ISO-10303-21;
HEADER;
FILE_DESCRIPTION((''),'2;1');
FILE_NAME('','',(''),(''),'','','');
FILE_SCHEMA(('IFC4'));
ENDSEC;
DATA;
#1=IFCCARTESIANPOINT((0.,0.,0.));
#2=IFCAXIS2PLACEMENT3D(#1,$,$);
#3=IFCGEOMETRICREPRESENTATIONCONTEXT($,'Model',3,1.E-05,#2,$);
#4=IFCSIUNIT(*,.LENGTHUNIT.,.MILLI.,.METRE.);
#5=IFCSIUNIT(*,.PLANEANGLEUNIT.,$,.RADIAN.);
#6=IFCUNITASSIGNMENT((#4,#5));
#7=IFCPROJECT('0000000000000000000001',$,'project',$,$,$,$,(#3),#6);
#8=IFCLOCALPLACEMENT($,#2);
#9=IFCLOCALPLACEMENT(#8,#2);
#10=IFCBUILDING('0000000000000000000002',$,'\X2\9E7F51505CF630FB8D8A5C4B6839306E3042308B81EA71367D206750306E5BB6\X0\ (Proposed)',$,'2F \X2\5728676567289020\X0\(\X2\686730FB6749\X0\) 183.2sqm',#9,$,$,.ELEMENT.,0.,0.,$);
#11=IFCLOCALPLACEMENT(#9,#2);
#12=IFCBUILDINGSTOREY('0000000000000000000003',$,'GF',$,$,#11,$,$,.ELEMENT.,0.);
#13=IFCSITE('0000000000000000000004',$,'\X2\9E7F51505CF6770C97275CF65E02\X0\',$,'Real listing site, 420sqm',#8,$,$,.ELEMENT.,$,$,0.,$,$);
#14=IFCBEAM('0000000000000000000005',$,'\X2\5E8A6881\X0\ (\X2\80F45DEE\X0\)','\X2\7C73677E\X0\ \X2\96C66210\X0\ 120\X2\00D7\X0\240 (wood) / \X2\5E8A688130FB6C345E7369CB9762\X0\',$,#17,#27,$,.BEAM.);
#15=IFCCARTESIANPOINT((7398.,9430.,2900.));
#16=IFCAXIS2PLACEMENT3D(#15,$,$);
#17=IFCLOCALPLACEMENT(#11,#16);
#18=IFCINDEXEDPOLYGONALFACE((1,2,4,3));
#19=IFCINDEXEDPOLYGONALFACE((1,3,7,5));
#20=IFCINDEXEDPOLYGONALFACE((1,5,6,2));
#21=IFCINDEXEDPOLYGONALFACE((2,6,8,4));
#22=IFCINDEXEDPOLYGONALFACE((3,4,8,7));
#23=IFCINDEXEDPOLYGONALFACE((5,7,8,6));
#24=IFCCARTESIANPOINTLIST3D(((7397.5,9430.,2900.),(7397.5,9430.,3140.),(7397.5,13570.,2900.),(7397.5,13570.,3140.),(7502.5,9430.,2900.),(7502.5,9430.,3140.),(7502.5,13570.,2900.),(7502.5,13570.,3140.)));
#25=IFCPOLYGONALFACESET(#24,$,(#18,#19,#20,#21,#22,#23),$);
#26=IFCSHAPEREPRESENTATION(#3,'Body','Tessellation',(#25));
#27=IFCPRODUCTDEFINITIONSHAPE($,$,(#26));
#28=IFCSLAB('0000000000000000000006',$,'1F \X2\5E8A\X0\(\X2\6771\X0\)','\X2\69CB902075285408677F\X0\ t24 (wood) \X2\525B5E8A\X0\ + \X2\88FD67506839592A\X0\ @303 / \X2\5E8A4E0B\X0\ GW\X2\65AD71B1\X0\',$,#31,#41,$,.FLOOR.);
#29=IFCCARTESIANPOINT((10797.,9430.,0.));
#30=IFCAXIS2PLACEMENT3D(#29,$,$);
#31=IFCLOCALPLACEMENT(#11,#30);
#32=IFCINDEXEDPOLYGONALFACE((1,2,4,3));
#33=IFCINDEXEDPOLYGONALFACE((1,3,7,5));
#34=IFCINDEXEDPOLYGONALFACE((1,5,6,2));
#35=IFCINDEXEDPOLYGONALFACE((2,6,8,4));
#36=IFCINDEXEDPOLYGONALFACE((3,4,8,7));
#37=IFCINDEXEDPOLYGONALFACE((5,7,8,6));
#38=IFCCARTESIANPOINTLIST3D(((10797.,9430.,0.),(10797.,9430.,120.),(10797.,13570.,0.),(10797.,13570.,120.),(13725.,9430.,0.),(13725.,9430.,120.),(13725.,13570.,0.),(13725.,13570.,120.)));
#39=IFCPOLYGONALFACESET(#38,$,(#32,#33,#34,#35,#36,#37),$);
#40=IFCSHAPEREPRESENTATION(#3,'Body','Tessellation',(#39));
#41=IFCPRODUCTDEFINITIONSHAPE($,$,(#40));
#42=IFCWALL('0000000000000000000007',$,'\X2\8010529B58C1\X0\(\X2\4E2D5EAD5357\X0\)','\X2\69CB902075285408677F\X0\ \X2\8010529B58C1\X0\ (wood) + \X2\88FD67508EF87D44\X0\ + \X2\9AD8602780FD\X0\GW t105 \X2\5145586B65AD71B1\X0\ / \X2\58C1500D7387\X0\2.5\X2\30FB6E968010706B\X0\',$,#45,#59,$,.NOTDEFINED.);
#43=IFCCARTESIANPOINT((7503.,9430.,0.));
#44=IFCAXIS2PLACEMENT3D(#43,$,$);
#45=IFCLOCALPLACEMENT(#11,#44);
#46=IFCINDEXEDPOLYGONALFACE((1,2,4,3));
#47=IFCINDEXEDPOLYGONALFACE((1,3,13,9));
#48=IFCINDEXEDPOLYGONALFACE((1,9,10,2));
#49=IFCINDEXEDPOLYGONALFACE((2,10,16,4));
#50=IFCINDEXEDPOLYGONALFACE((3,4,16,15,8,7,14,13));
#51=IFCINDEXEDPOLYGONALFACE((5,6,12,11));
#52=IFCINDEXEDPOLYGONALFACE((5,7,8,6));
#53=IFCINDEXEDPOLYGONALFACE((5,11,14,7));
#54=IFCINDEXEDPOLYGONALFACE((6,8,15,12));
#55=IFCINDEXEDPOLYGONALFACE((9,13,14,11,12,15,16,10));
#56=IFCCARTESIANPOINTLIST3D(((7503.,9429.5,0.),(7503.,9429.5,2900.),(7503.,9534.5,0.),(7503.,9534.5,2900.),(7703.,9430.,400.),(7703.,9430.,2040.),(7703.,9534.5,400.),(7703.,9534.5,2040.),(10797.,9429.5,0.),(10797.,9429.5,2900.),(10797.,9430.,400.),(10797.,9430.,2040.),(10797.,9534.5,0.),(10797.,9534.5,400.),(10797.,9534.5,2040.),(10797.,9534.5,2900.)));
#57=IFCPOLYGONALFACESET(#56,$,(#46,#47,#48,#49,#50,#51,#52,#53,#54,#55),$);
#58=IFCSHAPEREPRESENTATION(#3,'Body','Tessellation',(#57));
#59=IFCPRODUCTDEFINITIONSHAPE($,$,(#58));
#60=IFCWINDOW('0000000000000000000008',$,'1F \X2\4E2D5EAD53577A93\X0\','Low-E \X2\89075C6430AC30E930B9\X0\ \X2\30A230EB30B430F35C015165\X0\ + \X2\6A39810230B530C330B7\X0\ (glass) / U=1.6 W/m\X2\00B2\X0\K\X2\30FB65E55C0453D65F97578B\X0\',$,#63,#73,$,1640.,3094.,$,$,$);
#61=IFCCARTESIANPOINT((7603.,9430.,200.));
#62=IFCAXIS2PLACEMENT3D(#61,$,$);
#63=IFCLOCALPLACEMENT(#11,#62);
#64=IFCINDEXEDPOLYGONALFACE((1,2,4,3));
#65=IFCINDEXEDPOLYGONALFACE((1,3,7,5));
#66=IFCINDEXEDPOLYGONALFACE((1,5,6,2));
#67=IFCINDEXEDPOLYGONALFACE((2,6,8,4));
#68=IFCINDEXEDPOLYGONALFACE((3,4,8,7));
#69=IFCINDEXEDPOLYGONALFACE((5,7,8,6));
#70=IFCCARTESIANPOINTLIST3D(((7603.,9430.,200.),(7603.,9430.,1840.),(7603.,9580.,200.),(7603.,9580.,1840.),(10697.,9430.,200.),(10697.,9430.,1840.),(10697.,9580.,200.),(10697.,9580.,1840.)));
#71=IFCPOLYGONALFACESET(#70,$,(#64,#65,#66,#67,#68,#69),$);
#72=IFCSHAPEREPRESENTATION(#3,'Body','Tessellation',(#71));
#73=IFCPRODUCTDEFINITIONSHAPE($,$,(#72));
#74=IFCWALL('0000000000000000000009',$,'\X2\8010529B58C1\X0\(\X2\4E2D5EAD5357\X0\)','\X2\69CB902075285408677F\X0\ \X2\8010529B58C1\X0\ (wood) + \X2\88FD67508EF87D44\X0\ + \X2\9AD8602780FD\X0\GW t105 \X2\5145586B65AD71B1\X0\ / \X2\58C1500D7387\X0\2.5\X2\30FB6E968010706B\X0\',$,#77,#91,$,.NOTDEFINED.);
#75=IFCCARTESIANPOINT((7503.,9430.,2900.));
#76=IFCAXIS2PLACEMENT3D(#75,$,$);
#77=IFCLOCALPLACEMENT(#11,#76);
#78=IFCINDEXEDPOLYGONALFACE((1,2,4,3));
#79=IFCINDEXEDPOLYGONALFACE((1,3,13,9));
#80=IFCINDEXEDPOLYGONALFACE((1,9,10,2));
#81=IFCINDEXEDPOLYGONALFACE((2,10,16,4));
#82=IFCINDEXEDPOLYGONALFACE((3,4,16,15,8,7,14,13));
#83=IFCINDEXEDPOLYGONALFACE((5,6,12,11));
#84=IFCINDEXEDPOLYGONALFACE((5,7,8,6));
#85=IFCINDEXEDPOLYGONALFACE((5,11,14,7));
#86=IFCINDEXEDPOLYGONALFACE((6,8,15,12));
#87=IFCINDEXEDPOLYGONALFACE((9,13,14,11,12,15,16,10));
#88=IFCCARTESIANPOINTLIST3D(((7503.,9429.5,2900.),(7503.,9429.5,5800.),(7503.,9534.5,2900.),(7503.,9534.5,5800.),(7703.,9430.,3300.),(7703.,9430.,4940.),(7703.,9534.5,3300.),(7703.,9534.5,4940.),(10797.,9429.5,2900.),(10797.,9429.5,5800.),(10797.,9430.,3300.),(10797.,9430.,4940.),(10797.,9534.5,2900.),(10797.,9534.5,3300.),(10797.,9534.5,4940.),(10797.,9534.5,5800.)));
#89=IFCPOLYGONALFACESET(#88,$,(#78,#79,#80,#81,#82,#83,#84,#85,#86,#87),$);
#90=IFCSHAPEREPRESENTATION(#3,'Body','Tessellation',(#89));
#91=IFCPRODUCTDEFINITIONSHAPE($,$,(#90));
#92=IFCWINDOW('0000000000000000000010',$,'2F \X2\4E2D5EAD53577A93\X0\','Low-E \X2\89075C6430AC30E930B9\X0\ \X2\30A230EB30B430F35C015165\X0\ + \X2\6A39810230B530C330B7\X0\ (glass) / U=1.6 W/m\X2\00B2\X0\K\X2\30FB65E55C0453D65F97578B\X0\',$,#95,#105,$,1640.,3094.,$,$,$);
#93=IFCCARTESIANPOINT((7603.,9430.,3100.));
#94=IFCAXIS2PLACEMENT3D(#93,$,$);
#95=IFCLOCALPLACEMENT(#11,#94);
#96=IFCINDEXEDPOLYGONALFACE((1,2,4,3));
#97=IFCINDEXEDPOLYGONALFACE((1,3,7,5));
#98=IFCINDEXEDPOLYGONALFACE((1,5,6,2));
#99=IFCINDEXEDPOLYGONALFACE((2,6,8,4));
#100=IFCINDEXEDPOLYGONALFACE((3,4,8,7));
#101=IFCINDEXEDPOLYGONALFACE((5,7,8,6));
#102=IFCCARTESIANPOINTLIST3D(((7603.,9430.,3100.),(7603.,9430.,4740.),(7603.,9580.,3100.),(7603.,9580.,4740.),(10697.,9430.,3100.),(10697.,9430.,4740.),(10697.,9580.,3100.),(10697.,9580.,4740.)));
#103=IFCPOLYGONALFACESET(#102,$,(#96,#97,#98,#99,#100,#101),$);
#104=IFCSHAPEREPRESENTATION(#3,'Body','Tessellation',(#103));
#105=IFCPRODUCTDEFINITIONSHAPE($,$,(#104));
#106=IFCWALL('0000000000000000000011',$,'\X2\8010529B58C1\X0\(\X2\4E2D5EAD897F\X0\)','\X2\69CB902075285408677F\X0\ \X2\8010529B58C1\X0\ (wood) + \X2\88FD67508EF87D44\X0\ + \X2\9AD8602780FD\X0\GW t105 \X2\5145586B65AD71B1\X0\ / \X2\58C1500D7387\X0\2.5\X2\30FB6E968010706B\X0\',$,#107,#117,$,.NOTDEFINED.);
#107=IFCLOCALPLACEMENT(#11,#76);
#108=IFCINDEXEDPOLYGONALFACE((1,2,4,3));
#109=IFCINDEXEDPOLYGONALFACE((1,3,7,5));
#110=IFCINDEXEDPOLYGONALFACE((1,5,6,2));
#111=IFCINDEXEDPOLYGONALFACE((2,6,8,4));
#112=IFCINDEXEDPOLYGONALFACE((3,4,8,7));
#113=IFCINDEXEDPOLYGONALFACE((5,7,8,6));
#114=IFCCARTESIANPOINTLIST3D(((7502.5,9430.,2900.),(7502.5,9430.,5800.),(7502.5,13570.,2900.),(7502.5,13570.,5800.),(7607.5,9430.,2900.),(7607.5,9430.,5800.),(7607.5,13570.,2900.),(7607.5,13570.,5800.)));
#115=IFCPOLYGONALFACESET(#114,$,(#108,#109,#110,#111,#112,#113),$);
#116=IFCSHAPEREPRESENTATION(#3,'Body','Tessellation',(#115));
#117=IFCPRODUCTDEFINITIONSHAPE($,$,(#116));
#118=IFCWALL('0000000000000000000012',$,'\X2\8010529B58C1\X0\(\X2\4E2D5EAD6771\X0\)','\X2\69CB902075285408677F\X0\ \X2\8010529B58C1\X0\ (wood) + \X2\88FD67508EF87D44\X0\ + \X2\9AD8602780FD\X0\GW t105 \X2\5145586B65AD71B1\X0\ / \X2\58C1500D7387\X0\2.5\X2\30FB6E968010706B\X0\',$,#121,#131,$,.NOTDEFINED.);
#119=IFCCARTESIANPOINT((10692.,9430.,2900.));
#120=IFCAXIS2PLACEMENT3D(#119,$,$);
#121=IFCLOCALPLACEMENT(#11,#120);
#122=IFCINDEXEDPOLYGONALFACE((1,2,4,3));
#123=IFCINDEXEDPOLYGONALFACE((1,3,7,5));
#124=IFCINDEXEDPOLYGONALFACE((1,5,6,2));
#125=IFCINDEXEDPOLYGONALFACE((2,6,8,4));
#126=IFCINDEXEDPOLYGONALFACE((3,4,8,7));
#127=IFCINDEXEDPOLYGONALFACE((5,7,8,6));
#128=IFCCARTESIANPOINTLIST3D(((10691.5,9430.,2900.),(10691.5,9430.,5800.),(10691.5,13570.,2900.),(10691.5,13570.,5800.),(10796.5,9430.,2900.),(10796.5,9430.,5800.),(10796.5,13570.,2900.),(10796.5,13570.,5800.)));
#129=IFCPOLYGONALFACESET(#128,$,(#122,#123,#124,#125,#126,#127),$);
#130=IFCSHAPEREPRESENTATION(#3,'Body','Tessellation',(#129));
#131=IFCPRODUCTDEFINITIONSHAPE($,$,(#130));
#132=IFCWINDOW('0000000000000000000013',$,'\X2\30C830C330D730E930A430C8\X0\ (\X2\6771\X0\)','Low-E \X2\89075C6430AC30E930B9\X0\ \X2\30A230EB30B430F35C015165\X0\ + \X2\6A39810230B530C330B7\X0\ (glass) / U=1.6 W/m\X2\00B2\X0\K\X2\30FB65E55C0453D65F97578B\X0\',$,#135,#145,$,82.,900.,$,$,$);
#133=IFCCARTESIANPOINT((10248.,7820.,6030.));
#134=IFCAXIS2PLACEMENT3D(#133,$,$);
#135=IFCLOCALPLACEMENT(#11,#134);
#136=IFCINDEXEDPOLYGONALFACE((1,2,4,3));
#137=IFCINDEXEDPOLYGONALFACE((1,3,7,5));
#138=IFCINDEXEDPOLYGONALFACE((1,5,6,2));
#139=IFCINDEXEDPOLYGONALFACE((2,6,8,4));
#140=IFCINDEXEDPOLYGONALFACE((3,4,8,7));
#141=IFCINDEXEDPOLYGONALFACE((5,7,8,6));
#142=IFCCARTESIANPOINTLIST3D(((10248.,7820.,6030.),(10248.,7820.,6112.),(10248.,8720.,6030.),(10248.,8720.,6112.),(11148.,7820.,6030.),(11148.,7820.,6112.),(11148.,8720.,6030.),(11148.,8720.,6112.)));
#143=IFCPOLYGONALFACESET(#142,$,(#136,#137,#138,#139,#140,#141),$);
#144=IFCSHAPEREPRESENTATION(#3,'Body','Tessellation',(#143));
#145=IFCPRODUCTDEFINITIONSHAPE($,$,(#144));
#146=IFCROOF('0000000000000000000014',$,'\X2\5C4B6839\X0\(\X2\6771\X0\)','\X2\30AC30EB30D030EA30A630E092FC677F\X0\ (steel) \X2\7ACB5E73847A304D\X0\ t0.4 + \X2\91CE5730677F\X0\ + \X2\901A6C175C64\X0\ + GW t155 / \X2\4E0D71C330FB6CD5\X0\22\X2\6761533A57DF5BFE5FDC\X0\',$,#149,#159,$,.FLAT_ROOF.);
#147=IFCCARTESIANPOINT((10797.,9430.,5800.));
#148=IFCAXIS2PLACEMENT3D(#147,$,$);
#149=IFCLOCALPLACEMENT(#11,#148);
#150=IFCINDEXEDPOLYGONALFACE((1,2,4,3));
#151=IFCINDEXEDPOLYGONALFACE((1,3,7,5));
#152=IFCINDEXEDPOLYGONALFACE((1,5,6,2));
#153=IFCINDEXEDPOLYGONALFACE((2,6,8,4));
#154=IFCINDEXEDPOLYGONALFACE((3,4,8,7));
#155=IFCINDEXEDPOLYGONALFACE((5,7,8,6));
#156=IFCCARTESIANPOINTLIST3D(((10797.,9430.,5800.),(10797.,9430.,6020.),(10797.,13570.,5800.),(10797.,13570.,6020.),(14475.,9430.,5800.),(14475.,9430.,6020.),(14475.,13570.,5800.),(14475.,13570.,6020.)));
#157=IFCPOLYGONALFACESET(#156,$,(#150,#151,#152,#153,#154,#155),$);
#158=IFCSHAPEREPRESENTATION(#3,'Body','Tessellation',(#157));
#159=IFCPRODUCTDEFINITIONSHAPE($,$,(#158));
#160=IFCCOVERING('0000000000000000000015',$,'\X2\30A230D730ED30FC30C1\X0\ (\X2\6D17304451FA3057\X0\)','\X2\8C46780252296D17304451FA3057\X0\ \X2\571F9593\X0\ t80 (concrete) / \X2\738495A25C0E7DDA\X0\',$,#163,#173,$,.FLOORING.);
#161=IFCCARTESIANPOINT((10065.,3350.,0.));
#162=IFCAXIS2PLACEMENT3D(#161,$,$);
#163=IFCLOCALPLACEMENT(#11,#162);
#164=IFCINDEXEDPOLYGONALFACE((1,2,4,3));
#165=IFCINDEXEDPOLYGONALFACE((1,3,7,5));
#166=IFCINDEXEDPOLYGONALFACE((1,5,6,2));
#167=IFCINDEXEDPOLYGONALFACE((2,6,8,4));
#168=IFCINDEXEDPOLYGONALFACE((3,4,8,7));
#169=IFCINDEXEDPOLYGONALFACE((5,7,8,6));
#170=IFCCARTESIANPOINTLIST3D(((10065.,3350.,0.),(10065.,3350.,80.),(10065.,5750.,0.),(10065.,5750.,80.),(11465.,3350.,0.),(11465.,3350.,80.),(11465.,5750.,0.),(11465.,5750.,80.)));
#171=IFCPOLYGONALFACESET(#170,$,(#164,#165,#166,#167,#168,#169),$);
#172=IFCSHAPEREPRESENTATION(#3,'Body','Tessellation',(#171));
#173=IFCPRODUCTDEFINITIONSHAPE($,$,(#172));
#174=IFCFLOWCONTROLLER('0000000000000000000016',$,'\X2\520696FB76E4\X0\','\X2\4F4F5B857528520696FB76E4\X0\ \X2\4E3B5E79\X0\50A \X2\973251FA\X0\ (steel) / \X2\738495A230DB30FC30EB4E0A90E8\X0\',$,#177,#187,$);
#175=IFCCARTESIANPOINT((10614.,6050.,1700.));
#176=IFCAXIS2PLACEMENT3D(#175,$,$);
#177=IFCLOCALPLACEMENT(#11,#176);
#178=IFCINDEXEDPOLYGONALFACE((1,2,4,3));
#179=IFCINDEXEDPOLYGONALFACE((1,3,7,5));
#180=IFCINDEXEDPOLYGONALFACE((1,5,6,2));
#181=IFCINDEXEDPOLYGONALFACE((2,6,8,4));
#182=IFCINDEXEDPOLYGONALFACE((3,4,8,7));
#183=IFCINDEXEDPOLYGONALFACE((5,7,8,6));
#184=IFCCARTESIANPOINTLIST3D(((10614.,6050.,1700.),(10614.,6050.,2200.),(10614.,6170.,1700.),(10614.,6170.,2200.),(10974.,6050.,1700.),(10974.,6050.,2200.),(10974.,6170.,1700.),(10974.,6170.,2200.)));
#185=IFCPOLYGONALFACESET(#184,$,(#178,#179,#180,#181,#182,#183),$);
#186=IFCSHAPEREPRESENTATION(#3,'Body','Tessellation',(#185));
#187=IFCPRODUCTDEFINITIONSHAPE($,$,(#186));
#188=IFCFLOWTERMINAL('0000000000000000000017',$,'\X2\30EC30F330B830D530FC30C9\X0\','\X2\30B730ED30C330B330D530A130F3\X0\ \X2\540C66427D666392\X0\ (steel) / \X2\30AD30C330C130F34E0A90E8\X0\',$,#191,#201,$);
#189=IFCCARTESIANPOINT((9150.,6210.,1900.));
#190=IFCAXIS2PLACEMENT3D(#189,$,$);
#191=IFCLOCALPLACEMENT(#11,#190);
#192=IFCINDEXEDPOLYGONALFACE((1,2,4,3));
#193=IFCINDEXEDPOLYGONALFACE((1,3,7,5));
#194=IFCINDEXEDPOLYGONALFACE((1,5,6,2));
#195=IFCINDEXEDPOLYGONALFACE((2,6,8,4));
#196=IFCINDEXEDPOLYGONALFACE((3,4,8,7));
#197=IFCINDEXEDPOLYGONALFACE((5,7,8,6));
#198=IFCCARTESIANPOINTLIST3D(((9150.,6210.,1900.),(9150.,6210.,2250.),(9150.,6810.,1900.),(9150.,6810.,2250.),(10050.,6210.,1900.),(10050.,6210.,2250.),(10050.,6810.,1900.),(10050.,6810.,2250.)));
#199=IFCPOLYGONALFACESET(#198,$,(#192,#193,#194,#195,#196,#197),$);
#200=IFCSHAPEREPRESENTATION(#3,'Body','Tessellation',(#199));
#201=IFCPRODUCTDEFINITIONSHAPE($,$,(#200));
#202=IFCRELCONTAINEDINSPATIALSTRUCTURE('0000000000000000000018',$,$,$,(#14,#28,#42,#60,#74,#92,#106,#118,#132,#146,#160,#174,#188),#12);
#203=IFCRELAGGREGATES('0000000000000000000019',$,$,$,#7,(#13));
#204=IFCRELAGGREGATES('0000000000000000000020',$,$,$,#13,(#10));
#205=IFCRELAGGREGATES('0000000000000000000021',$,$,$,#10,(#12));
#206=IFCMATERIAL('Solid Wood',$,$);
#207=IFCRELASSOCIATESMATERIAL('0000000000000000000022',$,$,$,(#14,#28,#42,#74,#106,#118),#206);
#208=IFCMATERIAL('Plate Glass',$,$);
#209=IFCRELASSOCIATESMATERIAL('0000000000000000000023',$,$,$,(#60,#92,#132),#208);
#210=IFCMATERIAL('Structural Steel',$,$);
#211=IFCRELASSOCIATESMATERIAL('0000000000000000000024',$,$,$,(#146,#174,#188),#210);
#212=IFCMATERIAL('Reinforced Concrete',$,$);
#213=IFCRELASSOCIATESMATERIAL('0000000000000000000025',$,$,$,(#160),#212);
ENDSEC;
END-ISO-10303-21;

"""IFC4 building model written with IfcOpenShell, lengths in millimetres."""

from ifc_helpers import new_model, si_unit, frame, frame_2d, origin, place, context, project, spatial, rectangle, extrude, material, element, fill, save


model = new_model("IFC4")

# Units and contexts
model_context = context("Model", 3, precision=1e-05, world=origin())
ifc_project = project(units=[si_unit("LENGTHUNIT", "METRE", prefix="MILLI"), si_unit("PLANEANGLEUNIT", "RADIAN")], contexts=[model_context])

# Site, building, storey
site_placement = place(None, origin())
site = spatial("IfcSite", under=ifc_project, at=site_placement, Name="鹿児島県霧島市", ObjectType="Real listing site, 420sqm", CompositionType="ELEMENT", RefElevation=0.0)
building_placement = place(site_placement, origin())
building = spatial("IfcBuilding", under=site, at=building_placement, Name="鹿児島・越屋根のある自然素材の家 (Proposed)", ObjectType="2F 在来木造(桧・杉) 183.2sqm", CompositionType="ELEMENT", ElevationOfRefHeight=0.0, ElevationOfTerrain=0.0)
storey_placement = place(building_placement, origin())
storey = spatial("IfcBuildingStorey", under=building, at=storey_placement, Name="GF", CompositionType="ELEMENT", Elevation=0.0)

# Shared definitions
ifc_material_1 = material(Name="Solid Wood")

# Beam
beam_placement = place(storey_placement, frame((7398.0, 9430.0, 2900.0)))
element("IfcBeam", 1, at=beam_placement, inside=storey, material=ifc_material_1, Name="床梁 (胴差)", Description="米松 集成 120×240 (wood) / 床梁・水平構面", PredefinedType="BEAM", context=model_context, shape_type="SweptSolid", body=[
    extrude(rectangle(XDim=105.0, YDim=4140.0, at=frame_2d((52.0, 2070.0))), frame((7398.0, 9430.0, 2900.0)), (0.0, 0.0, 1.0), 240.0),
])

# Slab
slab_placement = place(storey_placement, frame((10797.0, 9430.0, 0.0)))
element("IfcSlab", 2, at=slab_placement, inside=storey, material=ifc_material_1, Name="1F 床(東)", Description="構造用合板 t24 (wood) 剛床 + 製材根太 @303 / 床下 GW断熱", PredefinedType="FLOOR", context=model_context, shape_type="SweptSolid", body=[
    extrude(rectangle(XDim=2928.0, YDim=4140.0, at=frame_2d((1464.0, 2070.0))), frame((10797.0, 9430.0, 0.0)), (0.0, 0.0, 1.0), 120.0),
])

# Wall, opening, window
wall_1_placement = place(storey_placement, frame((7503.0, 9430.0, 0.0)))
wall_1 = element("IfcWall", 3, at=wall_1_placement, inside=storey, material=ifc_material_1, Name="耐力壁(中庭南)", Description="構造用合板 耐力壁 (wood) + 製材軸組 + 高性能GW t105 充填断熱 / 壁倍率2.5・準耐火", PredefinedType="NOTDEFINED", context=model_context, shape_type="SweptSolid", body=[
    extrude(rectangle(XDim=3294.0, YDim=105.0, at=frame_2d((1647.0, 52.0))), frame((7503.0, 9430.0, 0.0)), (0.0, 0.0, 1.0), 2900.0),
])
opening_1_placement = place(storey_placement, frame((7603.0, 9430.0, 200.0)))
opening_1 = element("IfcOpeningElement", 4, at=opening_1_placement, cuts=wall_1, PredefinedType="NOTDEFINED", context=model_context, shape_type="SweptSolid", body=[
    extrude(rectangle(XDim=3094.0, YDim=150.0, at=frame_2d((1547.0, 75.0))), frame((7603.0, 9430.0, 200.0)), (0.0, 0.0, 1.0), 1640.0),
])
ifc_material_2 = material(Name="Plate Glass")
window_1_placement = place(storey_placement, frame((7603.0, 9430.0, 200.0)))
window_1 = element("IfcWindow", 5, at=window_1_placement, inside=storey, material=ifc_material_2, Name="1F 中庭南窓", Description="Low-E 複層ガラス アルゴン封入 + 樹脂サッシ (glass) / U=1.6 W/m²K・日射取得型", OverallHeight=1640.0, OverallWidth=3094.0, context=model_context, shape_type="SweptSolid", body=[
    extrude(rectangle(XDim=3094.0, YDim=150.0, at=frame_2d((1547.0, 75.0))), frame((7603.0, 9430.0, 200.0)), (0.0, 0.0, 1.0), 1640.0),
])
fill(opening_1, window_1)

# Wall, opening, window
wall_2_placement = place(storey_placement, frame((7503.0, 9430.0, 2900.0)))
wall_2 = element("IfcWall", 6, at=wall_2_placement, inside=storey, material=ifc_material_1, Name="耐力壁(中庭南)", Description="構造用合板 耐力壁 (wood) + 製材軸組 + 高性能GW t105 充填断熱 / 壁倍率2.5・準耐火", PredefinedType="NOTDEFINED", context=model_context, shape_type="SweptSolid", body=[
    extrude(rectangle(XDim=3294.0, YDim=105.0, at=frame_2d((1647.0, 52.0))), frame((7503.0, 9430.0, 2900.0)), (0.0, 0.0, 1.0), 2900.0),
])
opening_2_placement = place(storey_placement, frame((7603.0, 9430.0, 3100.0)))
opening_2 = element("IfcOpeningElement", 7, at=opening_2_placement, cuts=wall_2, PredefinedType="NOTDEFINED", context=model_context, shape_type="SweptSolid", body=[
    extrude(rectangle(XDim=3094.0, YDim=150.0, at=frame_2d((1547.0, 75.0))), frame((7603.0, 9430.0, 3100.0)), (0.0, 0.0, 1.0), 1640.0),
])
window_2_placement = place(storey_placement, frame((7603.0, 9430.0, 3100.0)))
window_2 = element("IfcWindow", 8, at=window_2_placement, inside=storey, material=ifc_material_2, Name="2F 中庭南窓", Description="Low-E 複層ガラス アルゴン封入 + 樹脂サッシ (glass) / U=1.6 W/m²K・日射取得型", OverallHeight=1640.0, OverallWidth=3094.0, context=model_context, shape_type="SweptSolid", body=[
    extrude(rectangle(XDim=3094.0, YDim=150.0, at=frame_2d((1547.0, 75.0))), frame((7603.0, 9430.0, 3100.0)), (0.0, 0.0, 1.0), 1640.0),
])
fill(opening_2, window_2)

# Walls
wall_3_placement = place(storey_placement, frame((7503.0, 9430.0, 2900.0)))
element("IfcWall", 9, at=wall_3_placement, inside=storey, material=ifc_material_1, Name="耐力壁(中庭西)", Description="構造用合板 耐力壁 (wood) + 製材軸組 + 高性能GW t105 充填断熱 / 壁倍率2.5・準耐火", PredefinedType="NOTDEFINED", context=model_context, shape_type="SweptSolid", body=[
    extrude(rectangle(XDim=105.0, YDim=4140.0, at=frame_2d((52.0, 2070.0))), frame((7503.0, 9430.0, 2900.0)), (0.0, 0.0, 1.0), 2900.0),
])
wall_4_placement = place(storey_placement, frame((10692.0, 9430.0, 2900.0)))
element("IfcWall", 10, at=wall_4_placement, inside=storey, material=ifc_material_1, Name="耐力壁(中庭東)", Description="構造用合板 耐力壁 (wood) + 製材軸組 + 高性能GW t105 充填断熱 / 壁倍率2.5・準耐火", PredefinedType="NOTDEFINED", context=model_context, shape_type="SweptSolid", body=[
    extrude(rectangle(XDim=105.0, YDim=4140.0, at=frame_2d((52.0, 2070.0))), frame((10692.0, 9430.0, 2900.0)), (0.0, 0.0, 1.0), 2900.0),
])

# Window
window_3_placement = place(storey_placement, frame((10248.0, 7820.0, 6030.0)))
element("IfcWindow", 11, at=window_3_placement, inside=storey, material=ifc_material_2, Name="トップライト (東)", Description="Low-E 複層ガラス アルゴン封入 + 樹脂サッシ (glass) / U=1.6 W/m²K・日射取得型", OverallHeight=82.0, OverallWidth=900.0, context=model_context, shape_type="SweptSolid", body=[
    extrude(rectangle(XDim=900.0, YDim=900.0, at=frame_2d((450.0, 450.0))), frame((10248.0, 7820.0, 6030.0)), (0.0, 0.0, 1.0), 82.0),
])

# Roof
ifc_material_3 = material(Name="Structural Steel")
roof_placement = place(storey_placement, frame((10797.0, 9430.0, 5800.0)))
element("IfcRoof", 12, at=roof_placement, inside=storey, material=ifc_material_3, Name="屋根(東)", Description="ガルバリウム鋼板 (steel) 立平葺き t0.4 + 野地板 + 通気層 + GW t155 / 不燃・法22条区域対応", PredefinedType="FLAT_ROOF", context=model_context, shape_type="SweptSolid", body=[
    extrude(rectangle(XDim=3678.0, YDim=4140.0, at=frame_2d((1839.0, 2070.0))), frame((10797.0, 9430.0, 5800.0)), (0.0, 0.0, 1.0), 220.0),
])

# Covering
ifc_material_4 = material(Name="Reinforced Concrete")
covering_placement = place(storey_placement, frame((10065.0, 3350.0, 0.0)))
element("IfcCovering", 13, at=covering_placement, inside=storey, material=ifc_material_4, Name="アプローチ (洗い出し)", Description="豆砂利洗い出し 土間 t80 (concrete) / 玄関導線", PredefinedType="FLOORING", context=model_context, shape_type="SweptSolid", body=[
    extrude(rectangle(XDim=1400.0, YDim=2400.0, at=frame_2d((700.0, 1200.0))), frame((10065.0, 3350.0, 0.0)), (0.0, 0.0, 1.0), 80.0),
])

# Flow controller
flow_controller_placement = place(storey_placement, frame((10614.0, 6050.0, 1700.0)))
element("IfcFlowController", 14, at=flow_controller_placement, inside=storey, material=ifc_material_3, Name="分電盤", Description="住宅用分電盤 主幹50A 露出 (steel) / 玄関ホール上部", context=model_context, shape_type="SweptSolid", body=[
    extrude(rectangle(XDim=360.0, YDim=120.0, at=frame_2d((180.0, 60.0))), frame((10614.0, 6050.0, 1700.0)), (0.0, 0.0, 1.0), 500.0),
])

# Flow terminal
flow_terminal_1_placement = place(storey_placement, frame((9150.0, 6210.0, 1900.0)))
element("IfcFlowTerminal", 15, at=flow_terminal_1_placement, inside=storey, material=ifc_material_3, Name="レンジフード", Description="シロッコファン 同時給排 (steel) / キッチン上部", context=model_context, shape_type="SweptSolid", body=[
    extrude(rectangle(XDim=900.0, YDim=600.0, at=frame_2d((450.0, 300.0))), frame((9150.0, 6210.0, 1900.0)), (0.0, 0.0, 1.0), 350.0),
])

save(model, "model.ifc")
